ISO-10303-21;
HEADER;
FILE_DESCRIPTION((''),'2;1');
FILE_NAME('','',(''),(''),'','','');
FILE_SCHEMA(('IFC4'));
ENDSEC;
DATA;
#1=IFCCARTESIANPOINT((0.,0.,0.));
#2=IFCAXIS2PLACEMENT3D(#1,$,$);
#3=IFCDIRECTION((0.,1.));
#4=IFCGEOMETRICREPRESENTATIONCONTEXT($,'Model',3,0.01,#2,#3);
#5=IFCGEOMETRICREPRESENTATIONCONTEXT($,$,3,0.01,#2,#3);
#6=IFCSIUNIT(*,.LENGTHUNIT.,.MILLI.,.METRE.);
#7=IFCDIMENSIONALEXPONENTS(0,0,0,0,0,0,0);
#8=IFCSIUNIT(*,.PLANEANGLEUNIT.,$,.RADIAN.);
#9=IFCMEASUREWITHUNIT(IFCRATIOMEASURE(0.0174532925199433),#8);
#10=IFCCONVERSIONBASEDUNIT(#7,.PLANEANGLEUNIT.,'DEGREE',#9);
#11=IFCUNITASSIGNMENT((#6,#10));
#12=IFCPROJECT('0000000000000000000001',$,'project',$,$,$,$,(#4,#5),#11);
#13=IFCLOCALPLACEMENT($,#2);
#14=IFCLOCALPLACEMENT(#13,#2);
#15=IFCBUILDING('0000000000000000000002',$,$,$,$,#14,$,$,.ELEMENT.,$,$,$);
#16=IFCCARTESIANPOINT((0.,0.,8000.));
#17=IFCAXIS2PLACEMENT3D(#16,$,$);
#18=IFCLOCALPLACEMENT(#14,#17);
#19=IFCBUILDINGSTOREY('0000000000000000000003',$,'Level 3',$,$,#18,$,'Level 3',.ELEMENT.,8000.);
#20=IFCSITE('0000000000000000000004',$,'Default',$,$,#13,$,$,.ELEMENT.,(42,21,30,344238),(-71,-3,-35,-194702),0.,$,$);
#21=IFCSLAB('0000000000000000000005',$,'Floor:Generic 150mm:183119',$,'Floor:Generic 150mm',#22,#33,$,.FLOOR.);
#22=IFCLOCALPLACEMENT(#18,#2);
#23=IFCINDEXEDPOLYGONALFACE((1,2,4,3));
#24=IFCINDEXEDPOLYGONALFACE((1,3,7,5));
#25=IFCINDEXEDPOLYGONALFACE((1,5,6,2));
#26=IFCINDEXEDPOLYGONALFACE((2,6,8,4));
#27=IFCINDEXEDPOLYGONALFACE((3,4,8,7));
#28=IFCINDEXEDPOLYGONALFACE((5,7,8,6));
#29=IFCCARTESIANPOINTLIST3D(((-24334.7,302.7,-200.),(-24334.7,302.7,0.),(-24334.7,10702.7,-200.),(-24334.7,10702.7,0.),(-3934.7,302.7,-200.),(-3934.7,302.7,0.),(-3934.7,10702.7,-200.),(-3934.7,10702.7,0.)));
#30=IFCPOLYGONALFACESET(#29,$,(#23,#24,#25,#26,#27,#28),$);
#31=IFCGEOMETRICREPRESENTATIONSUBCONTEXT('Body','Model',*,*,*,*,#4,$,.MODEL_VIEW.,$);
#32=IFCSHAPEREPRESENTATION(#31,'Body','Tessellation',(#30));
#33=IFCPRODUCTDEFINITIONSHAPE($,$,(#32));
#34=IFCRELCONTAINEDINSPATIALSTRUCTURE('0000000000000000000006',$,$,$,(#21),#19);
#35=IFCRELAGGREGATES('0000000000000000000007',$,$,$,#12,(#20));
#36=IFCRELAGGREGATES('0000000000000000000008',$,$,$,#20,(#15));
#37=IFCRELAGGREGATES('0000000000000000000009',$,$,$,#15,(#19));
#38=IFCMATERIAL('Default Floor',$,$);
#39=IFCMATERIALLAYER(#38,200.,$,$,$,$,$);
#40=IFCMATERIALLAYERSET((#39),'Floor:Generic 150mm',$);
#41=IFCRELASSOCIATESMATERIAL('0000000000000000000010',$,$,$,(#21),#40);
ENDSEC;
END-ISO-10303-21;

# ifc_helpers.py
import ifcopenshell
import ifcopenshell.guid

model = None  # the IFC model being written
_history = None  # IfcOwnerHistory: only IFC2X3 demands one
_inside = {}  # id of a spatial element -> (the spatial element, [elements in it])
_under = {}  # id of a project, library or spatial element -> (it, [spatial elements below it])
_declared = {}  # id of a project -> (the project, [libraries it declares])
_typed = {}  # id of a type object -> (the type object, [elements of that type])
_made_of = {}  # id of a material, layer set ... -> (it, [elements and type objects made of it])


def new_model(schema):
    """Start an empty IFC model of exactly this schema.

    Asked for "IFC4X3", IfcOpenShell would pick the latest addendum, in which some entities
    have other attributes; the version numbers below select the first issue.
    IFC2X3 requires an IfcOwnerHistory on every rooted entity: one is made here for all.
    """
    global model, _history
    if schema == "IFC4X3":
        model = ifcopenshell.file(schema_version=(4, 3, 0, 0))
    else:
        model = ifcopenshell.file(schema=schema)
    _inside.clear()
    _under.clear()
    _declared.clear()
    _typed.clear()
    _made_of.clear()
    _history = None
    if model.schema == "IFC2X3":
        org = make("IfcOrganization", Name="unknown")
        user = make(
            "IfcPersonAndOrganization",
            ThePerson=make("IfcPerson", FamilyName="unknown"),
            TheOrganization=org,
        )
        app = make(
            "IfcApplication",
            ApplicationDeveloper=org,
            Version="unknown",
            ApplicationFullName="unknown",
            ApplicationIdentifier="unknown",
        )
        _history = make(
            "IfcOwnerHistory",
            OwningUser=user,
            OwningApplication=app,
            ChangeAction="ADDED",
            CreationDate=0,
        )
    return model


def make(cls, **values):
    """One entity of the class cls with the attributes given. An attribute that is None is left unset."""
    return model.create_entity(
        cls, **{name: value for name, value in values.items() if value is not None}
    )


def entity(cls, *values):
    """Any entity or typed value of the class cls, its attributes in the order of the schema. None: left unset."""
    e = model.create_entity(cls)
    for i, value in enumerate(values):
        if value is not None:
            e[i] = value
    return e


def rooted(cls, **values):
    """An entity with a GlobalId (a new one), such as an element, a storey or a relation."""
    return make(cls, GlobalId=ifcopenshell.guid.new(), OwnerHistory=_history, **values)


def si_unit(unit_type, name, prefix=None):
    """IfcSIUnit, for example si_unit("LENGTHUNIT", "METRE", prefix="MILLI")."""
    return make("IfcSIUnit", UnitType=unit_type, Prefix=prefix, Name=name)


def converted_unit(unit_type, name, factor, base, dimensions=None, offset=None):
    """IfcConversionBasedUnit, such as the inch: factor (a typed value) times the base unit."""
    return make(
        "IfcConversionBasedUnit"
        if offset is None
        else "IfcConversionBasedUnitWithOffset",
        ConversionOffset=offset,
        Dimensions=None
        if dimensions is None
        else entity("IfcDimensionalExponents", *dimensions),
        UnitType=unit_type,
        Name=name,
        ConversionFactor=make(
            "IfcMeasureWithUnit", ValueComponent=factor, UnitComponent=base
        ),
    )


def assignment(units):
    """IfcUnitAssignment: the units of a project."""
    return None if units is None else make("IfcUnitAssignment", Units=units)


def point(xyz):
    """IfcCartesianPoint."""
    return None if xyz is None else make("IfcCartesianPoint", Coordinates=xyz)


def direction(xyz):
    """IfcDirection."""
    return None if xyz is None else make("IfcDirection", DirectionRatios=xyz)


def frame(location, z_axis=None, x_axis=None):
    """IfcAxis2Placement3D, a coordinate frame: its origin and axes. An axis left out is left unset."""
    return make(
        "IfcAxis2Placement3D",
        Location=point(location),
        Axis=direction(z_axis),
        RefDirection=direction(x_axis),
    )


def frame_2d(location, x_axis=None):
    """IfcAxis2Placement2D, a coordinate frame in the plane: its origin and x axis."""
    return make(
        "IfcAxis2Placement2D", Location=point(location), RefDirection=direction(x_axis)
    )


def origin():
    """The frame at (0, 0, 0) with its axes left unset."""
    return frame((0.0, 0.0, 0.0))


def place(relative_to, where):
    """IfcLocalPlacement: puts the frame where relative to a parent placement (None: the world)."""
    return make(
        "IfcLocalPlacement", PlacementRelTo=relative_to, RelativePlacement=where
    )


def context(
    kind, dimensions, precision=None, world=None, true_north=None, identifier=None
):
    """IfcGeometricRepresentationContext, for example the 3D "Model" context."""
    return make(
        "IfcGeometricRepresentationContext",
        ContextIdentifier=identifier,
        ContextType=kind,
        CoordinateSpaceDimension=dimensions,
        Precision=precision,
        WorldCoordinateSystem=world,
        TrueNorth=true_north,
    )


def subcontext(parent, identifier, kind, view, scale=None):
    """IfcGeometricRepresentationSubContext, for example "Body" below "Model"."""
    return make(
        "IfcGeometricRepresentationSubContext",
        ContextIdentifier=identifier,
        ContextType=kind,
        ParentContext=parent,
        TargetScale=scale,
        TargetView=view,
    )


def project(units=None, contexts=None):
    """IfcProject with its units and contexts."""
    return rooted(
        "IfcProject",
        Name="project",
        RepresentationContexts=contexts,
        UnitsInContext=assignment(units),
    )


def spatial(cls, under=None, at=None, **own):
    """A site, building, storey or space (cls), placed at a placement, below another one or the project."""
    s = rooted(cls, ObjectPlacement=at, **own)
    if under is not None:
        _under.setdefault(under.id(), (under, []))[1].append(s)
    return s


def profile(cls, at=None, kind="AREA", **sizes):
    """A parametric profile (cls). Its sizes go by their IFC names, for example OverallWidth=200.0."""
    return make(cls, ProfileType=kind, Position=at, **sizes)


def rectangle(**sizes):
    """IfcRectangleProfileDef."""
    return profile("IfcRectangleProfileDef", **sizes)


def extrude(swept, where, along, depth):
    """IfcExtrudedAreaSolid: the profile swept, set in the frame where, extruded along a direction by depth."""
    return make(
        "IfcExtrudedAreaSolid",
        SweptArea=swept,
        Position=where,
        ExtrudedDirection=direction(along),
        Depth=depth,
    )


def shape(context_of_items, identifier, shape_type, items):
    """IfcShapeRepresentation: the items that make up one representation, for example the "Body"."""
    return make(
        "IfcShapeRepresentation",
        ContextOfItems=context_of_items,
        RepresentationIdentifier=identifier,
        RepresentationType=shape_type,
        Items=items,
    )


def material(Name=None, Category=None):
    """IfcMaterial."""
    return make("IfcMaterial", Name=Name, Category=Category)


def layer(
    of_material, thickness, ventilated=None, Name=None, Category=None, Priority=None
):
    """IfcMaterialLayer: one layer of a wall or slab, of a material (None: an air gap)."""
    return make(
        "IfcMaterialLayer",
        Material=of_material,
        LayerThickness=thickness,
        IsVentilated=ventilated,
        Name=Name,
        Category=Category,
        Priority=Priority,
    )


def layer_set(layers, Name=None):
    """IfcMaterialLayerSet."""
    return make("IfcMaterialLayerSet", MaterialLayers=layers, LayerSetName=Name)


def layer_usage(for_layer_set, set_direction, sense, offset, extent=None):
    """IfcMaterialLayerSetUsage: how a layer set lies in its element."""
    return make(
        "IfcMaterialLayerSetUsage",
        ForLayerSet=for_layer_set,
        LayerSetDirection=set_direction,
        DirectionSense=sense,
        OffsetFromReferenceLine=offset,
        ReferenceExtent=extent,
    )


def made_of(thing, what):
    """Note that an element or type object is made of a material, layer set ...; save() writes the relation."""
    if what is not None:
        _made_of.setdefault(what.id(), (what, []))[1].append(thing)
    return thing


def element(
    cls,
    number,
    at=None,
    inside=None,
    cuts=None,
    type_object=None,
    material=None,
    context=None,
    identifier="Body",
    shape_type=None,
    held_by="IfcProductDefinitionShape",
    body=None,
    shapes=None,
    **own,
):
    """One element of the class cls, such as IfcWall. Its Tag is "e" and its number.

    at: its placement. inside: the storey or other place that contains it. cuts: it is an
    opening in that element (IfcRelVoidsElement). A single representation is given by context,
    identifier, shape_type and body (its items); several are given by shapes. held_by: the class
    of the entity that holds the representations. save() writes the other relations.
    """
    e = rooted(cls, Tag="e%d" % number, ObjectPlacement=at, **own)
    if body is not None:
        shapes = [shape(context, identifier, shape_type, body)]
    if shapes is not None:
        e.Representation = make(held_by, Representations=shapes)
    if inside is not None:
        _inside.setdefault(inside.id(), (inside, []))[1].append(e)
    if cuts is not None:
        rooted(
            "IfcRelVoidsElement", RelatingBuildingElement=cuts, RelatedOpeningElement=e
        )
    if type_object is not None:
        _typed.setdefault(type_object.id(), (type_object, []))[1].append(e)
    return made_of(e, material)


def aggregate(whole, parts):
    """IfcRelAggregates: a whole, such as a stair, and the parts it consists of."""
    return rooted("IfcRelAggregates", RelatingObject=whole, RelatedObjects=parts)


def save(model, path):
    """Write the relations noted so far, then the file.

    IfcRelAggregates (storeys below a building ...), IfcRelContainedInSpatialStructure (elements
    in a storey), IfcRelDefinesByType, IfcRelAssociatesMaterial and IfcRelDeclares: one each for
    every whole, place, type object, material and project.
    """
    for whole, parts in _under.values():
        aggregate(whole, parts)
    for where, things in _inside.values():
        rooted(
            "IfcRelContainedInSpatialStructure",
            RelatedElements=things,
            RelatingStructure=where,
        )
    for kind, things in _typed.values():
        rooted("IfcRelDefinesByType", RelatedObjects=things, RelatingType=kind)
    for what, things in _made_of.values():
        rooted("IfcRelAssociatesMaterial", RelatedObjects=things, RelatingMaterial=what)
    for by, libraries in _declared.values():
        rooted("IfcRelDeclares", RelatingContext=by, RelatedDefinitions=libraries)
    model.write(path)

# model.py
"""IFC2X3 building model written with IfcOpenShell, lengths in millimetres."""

from ifc_helpers import new_model, entity, si_unit, converted_unit, direction, frame, frame_2d, origin, place, context, subcontext, project, spatial, rectangle, extrude, material, layer, layer_set, layer_usage, element, save


model = new_model("IFC2X3")

# Units and contexts
model_context = context("Model", 3, precision=0.01, world=origin(), true_north=direction((0.0, 1.0)))
context_of_model = context(None, 3, precision=0.01, world=origin(), true_north=direction((0.0, 1.0)))
body_context = subcontext(model_context, "Body", "Model", "MODEL_VIEW")
ifc_project = project(units=[si_unit("LENGTHUNIT", "METRE", prefix="MILLI"), converted_unit("PLANEANGLEUNIT", "DEGREE", entity("IfcRatioMeasure", 0.0174532925199433), si_unit("PLANEANGLEUNIT", "RADIAN"), dimensions=[0, 0, 0, 0, 0, 0, 0])], contexts=[model_context, context_of_model])

# Site, building, storey
site_placement = place(None, origin())
site = spatial("IfcSite", under=ifc_project, at=site_placement, Name="Default", CompositionType="ELEMENT", RefLatitude=(42, 21, 30, 344238), RefLongitude=(-71, -3, -35, -194702), RefElevation=0.0)
building_placement = place(site_placement, origin())
building = spatial("IfcBuilding", under=site, at=building_placement, CompositionType="ELEMENT")
storey_placement = place(building_placement, frame((0.0, 0.0, 8000.0)))
storey = spatial("IfcBuildingStorey", under=building, at=storey_placement, Name="Level 3", LongName="Level 3", CompositionType="ELEMENT", Elevation=8000.0)

# Slab
ifc_material = material(Name="Default Floor")
ifc_layer = layer(ifc_material, 200.0)
ifc_layer_set = layer_set([ifc_layer], Name="Floor:Generic 150mm")
ifc_layer_usage = layer_usage(ifc_layer_set, "AXIS3", "POSITIVE", 0.0)
slab_placement = place(storey_placement, origin())
element("IfcSlab", 1, at=slab_placement, inside=storey, material=ifc_layer_usage, Name="Floor:Generic 150mm:183119", ObjectType="Floor:Generic 150mm", PredefinedType="FLOOR", context=body_context, shape_type="SweptSolid", body=[
    extrude(rectangle(XDim=10400.0, YDim=20400.0, at=frame_2d((0.0, 0.0), x_axis=(1.0, 0.0))), frame((-14134.7, 5502.7, 0.0), z_axis=(0.0, 0.0, -1.0), x_axis=(0.0, 1.0, 0.0)), (0.0, 0.0, 1.0), 200.0),
])

save(model, "model.ifc")
